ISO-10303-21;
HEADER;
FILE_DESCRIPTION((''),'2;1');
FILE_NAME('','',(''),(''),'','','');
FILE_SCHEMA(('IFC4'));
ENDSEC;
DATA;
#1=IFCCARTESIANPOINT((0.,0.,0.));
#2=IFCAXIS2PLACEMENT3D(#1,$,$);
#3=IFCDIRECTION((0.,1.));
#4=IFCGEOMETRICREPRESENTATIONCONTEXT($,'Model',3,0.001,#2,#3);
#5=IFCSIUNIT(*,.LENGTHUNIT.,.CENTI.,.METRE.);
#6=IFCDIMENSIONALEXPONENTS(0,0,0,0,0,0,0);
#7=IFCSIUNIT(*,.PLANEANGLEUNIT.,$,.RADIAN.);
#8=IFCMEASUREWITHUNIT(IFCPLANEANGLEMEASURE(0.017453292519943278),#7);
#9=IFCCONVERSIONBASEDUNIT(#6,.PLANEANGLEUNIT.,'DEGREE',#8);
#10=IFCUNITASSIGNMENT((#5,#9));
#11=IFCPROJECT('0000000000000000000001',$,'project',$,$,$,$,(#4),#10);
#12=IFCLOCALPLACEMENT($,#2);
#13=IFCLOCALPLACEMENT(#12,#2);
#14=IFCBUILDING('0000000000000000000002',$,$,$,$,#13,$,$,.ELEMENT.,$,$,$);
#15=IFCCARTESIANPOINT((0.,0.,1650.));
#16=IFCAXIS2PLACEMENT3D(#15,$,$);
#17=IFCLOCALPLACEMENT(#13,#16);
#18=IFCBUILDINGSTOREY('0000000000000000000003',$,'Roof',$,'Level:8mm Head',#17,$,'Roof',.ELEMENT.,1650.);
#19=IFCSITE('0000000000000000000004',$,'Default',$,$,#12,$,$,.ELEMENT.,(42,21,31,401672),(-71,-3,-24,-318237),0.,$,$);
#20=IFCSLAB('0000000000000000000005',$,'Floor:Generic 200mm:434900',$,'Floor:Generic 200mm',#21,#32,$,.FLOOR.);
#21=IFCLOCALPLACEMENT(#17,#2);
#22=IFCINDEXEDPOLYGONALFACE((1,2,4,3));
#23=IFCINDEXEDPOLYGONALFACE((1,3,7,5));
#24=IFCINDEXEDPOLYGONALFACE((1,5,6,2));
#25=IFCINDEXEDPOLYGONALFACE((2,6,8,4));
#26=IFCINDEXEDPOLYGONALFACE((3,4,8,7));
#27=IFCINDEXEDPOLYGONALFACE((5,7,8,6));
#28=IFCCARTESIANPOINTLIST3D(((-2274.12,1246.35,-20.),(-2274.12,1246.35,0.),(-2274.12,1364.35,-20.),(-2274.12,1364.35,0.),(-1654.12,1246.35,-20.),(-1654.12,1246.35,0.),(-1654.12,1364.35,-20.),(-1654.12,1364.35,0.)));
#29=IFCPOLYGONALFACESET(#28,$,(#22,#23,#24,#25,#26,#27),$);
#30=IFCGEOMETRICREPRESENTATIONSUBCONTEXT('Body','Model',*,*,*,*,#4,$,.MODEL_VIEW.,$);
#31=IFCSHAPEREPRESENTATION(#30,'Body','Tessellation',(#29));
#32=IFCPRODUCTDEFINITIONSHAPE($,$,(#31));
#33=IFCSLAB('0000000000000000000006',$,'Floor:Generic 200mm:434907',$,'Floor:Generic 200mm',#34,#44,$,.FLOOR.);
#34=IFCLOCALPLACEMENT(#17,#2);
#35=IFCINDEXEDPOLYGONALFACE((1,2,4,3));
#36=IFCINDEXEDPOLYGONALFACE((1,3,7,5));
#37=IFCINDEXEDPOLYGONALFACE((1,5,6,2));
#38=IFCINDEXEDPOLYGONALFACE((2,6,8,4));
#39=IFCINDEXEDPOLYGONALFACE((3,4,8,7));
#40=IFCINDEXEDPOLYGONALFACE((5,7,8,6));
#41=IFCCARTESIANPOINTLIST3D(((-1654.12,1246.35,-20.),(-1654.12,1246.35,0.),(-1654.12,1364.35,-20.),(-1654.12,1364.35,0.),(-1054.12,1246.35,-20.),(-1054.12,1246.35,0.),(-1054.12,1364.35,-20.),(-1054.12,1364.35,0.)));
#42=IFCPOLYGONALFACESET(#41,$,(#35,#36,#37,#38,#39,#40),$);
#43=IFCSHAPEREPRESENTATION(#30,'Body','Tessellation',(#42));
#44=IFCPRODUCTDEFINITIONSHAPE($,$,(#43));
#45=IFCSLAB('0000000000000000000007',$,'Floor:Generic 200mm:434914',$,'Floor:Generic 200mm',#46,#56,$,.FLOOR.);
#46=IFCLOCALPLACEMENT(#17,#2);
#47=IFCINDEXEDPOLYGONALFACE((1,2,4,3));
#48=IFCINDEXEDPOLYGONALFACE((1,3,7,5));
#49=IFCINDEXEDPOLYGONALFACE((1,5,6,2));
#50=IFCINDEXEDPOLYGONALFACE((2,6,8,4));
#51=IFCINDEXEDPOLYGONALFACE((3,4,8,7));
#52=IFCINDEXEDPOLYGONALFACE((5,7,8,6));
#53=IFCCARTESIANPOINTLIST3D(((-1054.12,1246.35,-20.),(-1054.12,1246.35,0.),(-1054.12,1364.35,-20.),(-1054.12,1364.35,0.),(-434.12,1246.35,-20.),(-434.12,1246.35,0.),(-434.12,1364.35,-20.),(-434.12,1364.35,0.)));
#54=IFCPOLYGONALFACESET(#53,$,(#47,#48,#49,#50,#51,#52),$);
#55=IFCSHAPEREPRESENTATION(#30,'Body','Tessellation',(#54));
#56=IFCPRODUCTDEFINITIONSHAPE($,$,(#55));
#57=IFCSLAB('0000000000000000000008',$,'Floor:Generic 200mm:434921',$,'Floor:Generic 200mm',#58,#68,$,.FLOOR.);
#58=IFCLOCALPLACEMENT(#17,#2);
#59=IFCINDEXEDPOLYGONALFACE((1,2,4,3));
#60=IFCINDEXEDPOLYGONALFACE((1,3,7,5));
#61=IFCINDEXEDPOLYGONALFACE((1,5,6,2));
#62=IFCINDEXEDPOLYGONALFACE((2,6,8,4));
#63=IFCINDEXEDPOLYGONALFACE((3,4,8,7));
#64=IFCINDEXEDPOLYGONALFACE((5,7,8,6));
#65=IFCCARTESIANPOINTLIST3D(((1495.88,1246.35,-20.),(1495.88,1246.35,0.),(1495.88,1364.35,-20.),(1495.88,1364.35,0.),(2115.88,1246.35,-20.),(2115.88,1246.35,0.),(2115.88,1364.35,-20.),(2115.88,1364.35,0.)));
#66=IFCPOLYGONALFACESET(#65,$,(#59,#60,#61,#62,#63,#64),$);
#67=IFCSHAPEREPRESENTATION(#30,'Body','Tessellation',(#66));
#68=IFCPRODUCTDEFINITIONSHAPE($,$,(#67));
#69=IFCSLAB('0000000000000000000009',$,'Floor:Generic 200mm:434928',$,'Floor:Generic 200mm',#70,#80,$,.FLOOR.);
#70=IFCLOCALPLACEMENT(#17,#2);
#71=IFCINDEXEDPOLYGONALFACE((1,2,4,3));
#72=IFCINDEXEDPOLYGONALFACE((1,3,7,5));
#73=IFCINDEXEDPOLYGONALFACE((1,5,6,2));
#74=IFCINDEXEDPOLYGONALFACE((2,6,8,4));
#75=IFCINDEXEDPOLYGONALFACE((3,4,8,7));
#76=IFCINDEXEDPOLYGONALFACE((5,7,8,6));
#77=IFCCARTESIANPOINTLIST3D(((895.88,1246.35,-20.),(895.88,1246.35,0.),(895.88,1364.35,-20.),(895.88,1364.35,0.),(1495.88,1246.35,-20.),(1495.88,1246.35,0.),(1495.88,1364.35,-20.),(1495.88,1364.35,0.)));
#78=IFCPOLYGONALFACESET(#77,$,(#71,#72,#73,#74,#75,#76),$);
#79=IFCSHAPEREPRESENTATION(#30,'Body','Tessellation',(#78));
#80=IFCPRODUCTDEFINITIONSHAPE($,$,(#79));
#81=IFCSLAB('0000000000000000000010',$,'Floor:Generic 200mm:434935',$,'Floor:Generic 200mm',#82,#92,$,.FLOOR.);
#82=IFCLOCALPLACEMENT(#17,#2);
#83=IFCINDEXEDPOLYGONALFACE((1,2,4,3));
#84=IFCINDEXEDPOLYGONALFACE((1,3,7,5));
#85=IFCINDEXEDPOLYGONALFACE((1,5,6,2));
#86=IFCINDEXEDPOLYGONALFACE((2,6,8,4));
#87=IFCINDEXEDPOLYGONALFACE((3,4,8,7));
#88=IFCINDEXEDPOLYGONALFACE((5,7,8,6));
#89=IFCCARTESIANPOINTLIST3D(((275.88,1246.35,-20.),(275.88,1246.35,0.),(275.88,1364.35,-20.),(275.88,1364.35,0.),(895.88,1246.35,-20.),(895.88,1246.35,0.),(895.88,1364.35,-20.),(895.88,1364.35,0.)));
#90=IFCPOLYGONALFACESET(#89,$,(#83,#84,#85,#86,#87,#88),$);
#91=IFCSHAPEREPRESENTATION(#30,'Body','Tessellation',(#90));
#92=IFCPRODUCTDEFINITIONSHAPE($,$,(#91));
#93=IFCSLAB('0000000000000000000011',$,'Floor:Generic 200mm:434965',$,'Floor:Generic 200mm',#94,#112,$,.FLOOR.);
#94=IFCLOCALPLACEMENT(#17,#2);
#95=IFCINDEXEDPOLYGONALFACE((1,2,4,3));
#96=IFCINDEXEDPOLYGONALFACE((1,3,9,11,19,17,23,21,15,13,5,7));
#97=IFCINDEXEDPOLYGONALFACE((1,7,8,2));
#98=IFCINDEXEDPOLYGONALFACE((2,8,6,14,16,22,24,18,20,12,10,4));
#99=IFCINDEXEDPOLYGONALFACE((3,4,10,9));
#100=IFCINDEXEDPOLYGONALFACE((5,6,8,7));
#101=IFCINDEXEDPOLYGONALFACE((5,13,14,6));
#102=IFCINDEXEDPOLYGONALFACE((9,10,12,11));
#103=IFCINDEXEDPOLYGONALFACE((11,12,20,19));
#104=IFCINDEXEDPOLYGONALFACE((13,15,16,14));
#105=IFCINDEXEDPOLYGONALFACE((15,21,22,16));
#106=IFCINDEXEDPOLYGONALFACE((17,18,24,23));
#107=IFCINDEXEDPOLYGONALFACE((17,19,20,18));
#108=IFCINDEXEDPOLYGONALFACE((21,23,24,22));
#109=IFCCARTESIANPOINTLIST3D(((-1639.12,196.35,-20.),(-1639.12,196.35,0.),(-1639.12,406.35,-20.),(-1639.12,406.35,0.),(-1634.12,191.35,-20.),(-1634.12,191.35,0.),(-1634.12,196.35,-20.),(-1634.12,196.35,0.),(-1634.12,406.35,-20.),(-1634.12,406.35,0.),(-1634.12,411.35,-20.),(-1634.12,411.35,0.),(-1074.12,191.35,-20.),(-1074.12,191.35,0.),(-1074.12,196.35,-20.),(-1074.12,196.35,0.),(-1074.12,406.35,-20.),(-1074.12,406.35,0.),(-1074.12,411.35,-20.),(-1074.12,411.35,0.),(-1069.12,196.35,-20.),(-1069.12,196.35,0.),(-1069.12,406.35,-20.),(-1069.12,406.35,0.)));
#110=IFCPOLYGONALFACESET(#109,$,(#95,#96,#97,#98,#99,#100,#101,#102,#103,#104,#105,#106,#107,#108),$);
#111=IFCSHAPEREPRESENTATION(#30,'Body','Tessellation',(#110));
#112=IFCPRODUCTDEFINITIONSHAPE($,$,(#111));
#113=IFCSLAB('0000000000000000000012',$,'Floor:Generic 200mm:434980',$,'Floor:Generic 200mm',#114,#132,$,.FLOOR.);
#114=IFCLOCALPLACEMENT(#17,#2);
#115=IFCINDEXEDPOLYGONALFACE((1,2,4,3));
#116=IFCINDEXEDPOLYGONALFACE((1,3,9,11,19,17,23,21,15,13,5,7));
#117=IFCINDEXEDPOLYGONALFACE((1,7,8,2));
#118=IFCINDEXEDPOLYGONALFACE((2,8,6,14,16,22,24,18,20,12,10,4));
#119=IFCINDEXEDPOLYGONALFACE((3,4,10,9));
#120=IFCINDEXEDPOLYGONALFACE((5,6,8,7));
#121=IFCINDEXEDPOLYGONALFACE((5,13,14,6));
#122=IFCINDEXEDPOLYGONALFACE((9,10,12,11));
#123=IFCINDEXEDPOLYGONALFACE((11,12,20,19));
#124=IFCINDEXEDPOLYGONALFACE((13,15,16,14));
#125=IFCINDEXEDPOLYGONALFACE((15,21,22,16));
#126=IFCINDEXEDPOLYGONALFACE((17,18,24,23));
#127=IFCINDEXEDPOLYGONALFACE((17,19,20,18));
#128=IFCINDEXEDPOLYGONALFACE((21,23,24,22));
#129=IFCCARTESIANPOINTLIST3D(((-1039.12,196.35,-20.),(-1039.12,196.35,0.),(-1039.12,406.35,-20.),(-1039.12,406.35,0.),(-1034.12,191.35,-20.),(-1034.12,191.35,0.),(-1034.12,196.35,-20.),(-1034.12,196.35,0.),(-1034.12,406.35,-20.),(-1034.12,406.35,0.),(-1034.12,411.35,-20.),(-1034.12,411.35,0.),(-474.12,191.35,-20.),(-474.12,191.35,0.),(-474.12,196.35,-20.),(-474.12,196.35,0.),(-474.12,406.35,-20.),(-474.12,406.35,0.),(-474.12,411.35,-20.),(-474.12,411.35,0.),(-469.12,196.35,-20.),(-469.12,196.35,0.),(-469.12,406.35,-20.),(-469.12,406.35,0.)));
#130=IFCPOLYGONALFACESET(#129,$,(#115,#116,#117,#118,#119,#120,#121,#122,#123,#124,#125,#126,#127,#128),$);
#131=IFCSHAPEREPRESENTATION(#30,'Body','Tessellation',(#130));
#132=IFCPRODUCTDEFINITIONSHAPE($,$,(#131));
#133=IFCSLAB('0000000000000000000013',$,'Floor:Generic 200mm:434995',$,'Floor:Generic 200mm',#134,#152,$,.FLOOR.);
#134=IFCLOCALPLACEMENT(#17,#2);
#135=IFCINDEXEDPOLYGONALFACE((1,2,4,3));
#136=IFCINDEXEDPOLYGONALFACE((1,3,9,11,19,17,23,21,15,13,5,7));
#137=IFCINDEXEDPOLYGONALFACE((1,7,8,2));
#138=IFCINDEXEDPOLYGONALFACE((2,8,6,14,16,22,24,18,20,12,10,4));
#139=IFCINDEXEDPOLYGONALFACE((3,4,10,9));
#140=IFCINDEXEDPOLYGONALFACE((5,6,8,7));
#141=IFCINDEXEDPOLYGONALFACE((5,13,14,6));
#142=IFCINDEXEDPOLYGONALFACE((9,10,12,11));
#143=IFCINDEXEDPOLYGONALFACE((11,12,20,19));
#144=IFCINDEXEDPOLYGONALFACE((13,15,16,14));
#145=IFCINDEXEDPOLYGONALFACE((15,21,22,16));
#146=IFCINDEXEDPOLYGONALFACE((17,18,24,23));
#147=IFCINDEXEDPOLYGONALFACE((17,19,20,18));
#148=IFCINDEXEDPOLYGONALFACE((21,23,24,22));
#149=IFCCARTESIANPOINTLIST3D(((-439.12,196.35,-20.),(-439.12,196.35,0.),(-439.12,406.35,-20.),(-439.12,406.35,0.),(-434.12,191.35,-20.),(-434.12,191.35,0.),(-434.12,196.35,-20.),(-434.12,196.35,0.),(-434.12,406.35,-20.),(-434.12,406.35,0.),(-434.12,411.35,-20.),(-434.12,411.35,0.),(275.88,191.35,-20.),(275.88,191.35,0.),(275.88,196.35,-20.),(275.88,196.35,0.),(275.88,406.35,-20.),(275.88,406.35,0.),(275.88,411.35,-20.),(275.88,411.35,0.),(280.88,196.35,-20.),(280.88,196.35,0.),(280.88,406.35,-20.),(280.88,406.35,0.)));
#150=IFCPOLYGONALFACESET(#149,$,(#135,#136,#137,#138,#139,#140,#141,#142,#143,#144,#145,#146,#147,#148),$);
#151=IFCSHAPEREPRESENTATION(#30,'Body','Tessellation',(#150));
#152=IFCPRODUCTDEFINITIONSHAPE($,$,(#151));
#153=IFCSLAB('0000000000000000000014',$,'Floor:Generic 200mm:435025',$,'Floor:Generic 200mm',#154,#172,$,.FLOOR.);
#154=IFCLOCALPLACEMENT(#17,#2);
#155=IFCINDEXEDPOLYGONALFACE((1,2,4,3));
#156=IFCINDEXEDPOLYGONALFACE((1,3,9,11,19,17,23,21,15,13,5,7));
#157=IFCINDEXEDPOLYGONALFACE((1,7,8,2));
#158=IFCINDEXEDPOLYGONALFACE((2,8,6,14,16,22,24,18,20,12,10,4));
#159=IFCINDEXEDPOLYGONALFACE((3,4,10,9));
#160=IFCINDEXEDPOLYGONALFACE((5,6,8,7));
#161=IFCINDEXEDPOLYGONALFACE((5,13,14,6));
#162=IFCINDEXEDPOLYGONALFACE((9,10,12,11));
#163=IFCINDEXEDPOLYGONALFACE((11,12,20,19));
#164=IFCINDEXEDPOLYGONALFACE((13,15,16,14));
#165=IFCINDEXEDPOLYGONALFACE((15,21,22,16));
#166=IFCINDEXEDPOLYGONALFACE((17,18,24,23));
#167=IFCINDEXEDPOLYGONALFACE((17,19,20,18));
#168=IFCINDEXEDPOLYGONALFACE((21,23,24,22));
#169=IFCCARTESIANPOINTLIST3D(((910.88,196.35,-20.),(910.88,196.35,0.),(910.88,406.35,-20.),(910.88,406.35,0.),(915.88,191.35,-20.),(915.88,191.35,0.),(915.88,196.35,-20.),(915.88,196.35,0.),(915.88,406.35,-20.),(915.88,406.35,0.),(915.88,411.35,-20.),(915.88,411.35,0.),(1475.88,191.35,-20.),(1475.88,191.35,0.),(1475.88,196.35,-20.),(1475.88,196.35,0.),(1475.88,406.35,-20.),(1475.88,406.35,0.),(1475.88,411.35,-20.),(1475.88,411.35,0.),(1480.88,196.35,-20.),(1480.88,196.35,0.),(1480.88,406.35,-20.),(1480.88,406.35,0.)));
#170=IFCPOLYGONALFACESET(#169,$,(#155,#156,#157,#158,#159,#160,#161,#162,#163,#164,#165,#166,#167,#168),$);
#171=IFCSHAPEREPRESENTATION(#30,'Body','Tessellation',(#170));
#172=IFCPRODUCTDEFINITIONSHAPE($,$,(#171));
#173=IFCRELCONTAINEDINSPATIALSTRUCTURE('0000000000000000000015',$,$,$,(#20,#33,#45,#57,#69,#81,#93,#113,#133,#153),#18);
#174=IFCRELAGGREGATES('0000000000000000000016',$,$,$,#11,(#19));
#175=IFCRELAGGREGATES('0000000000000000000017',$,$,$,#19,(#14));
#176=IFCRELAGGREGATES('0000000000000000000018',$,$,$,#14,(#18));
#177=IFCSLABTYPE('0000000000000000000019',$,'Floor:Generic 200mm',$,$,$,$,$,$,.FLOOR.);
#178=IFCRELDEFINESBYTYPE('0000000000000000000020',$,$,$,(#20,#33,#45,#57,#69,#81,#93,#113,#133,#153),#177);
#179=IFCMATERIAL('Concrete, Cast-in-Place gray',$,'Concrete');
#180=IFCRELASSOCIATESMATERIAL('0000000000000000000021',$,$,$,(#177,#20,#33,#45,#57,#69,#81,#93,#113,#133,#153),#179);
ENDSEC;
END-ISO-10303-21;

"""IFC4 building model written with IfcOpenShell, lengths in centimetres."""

from ifc_helpers import new_model, entity, si_unit, converted_unit, direction, frame, origin, place, context, subcontext, project, spatial, indexed_curve, outline, extrude, material, type_object, element, save


model = new_model("IFC4")

# Units and contexts
model_context = context("Model", 3, precision=0.001, world=origin(), true_north=direction((0.0, 1.0)))
body_context = subcontext(model_context, "Body", "Model", "MODEL_VIEW")
ifc_project = project(units=[si_unit("LENGTHUNIT", "METRE", prefix="CENTI"), converted_unit("PLANEANGLEUNIT", "DEGREE", entity("IfcPlaneAngleMeasure", 0.017453292519943278), si_unit("PLANEANGLEUNIT", "RADIAN"), dimensions=[0, 0, 0, 0, 0, 0, 0])], contexts=[model_context])

# Site, building, storey
site_placement = place(None, origin())
site = spatial("IfcSite", under=ifc_project, at=site_placement, Name="Default", CompositionType="ELEMENT", RefLatitude=(42, 21, 31, 401672), RefLongitude=(-71, -3, -24, -318237), RefElevation=0.0)
building_placement = place(site_placement, origin())
building = spatial("IfcBuilding", under=site, at=building_placement, CompositionType="ELEMENT")
storey_placement = place(building_placement, frame((0.0, 0.0, 1650.0)))
storey = spatial("IfcBuildingStorey", under=building, at=storey_placement, Name="Roof", ObjectType="Level:8mm Head", LongName="Roof", CompositionType="ELEMENT", Elevation=1650.0)

# Slabs
ifc_material = material(Name="Concrete, Cast-in-Place gray", Category="Concrete")
slab_type = type_object("IfcSlabType", Name="Floor:Generic 200mm", PredefinedType="FLOOR", material=ifc_material)
slab_1_placement = place(storey_placement, origin())
element("IfcSlab", 1, at=slab_1_placement, inside=storey, type_object=slab_type, material=ifc_material, Name="Floor:Generic 200mm:434900", ObjectType="Floor:Generic 200mm", PredefinedType="FLOOR", context=body_context, shape_type="SweptSolid", body=[
    extrude(outline(indexed_curve([(-59.0, -310.0), (59.0, -310.0), (59.0, 310.0), (-59.0, 310.0), (-59.0, -310.0)], self_intersect=False)), frame((-1964.12, 1305.35, 0.0), z_axis=(0.0, 0.0, -1.0), x_axis=(0.0, 1.0, 0.0)), (0.0, 0.0, 1.0), 20.0),
])
slab_2_placement = place(storey_placement, origin())
element("IfcSlab", 2, at=slab_2_placement, inside=storey, type_object=slab_type, material=ifc_material, Name="Floor:Generic 200mm:434907", ObjectType="Floor:Generic 200mm", PredefinedType="FLOOR", context=body_context, shape_type="SweptSolid", body=[
    extrude(outline(indexed_curve([(-59.0, -300.0), (59.0, -300.0), (59.0, 300.0), (-59.0, 300.0), (-59.0, -300.0)], self_intersect=False)), frame((-1354.12, 1305.35, 0.0), z_axis=(0.0, 0.0, -1.0), x_axis=(0.0, 1.0, 0.0)), (0.0, 0.0, 1.0), 20.0),
])
slab_3_placement = place(storey_placement, origin())
element("IfcSlab", 3, at=slab_3_placement, inside=storey, type_object=slab_type, material=ifc_material, Name="Floor:Generic 200mm:434914", ObjectType="Floor:Generic 200mm", PredefinedType="FLOOR", context=body_context, shape_type="SweptSolid", body=[
    extrude(outline(indexed_curve([(-59.0, -310.0), (59.0, -310.0), (59.0, 310.0), (-59.0, 310.0), (-59.0, -310.0)], self_intersect=False)), frame((-744.12, 1305.35, 0.0), z_axis=(0.0, 0.0, -1.0), x_axis=(0.0, 1.0, 0.0)), (0.0, 0.0, 1.0), 20.0),
])
slab_4_placement = place(storey_placement, origin())
element("IfcSlab", 4, at=slab_4_placement, inside=storey, type_object=slab_type, material=ifc_material, Name="Floor:Generic 200mm:434921", ObjectType="Floor:Generic 200mm", PredefinedType="FLOOR", context=body_context, shape_type="SweptSolid", body=[
    extrude(outline(indexed_curve([(-59.0, -310.0), (59.0, -310.0), (59.0, 310.0), (-59.0, 310.0), (-59.0, -310.0)], self_intersect=False)), frame((1805.88, 1305.35, 0.0), z_axis=(0.0, 0.0, -1.0), x_axis=(0.0, 1.0, 0.0)), (0.0, 0.0, 1.0), 20.0),
])
slab_5_placement = place(storey_placement, origin())
element("IfcSlab", 5, at=slab_5_placement, inside=storey, type_object=slab_type, material=ifc_material, Name="Floor:Generic 200mm:434928", ObjectType="Floor:Generic 200mm", PredefinedType="FLOOR", context=body_context, shape_type="SweptSolid", body=[
    extrude(outline(indexed_curve([(-59.0, -300.0), (59.0, -300.0), (59.0, 300.0), (-59.0, 300.0), (-59.0, -300.0)], self_intersect=False)), frame((1195.88, 1305.35, 0.0), z_axis=(0.0, 0.0, -1.0), x_axis=(0.0, 1.0, 0.0)), (0.0, 0.0, 1.0), 20.0),
])
slab_6_placement = place(storey_placement, origin())
element("IfcSlab", 6, at=slab_6_placement, inside=storey, type_object=slab_type, material=ifc_material, Name="Floor:Generic 200mm:434935", ObjectType="Floor:Generic 200mm", PredefinedType="FLOOR", context=body_context, shape_type="SweptSolid", body=[
    extrude(outline(indexed_curve([(-59.0, -310.0), (59.0, -310.0), (59.0, 310.0), (-59.0, 310.0), (-59.0, -310.0)], self_intersect=False)), frame((585.88, 1305.35, 0.0), z_axis=(0.0, 0.0, -1.0), x_axis=(0.0, 1.0, 0.0)), (0.0, 0.0, 1.0), 20.0),
])
slab_7_placement = place(storey_placement, origin())
element("IfcSlab", 7, at=slab_7_placement, inside=storey, type_object=slab_type, material=ifc_material, Name="Floor:Generic 200mm:434965", ObjectType="Floor:Generic 200mm", PredefinedType="FLOOR", context=body_context, shape_type="SweptSolid", body=[
    extrude(outline(indexed_curve([(-105.0, -285.0), (105.0, -285.0), (105.0, -280.0), (110.0, -280.0), (110.0, 280.0), (105.0, 280.0), (105.0, 285.0), (-105.0, 285.0), (-105.0, 280.0), (-110.0, 280.0), (-110.0, -280.0), (-105.0, -280.0), (-105.0, -285.0)], self_intersect=False)), frame((-1354.12, 301.35, 0.0), z_axis=(0.0, 0.0, -1.0), x_axis=(0.0, 1.0, 0.0)), (0.0, 0.0, 1.0), 20.0),
])
slab_8_placement = place(storey_placement, origin())
element("IfcSlab", 8, at=slab_8_placement, inside=storey, type_object=slab_type, material=ifc_material, Name="Floor:Generic 200mm:434980", ObjectType="Floor:Generic 200mm", PredefinedType="FLOOR", context=body_context, shape_type="SweptSolid", body=[
    extrude(outline(indexed_curve([(-105.0, -285.0), (105.0, -285.0), (105.0, -280.0), (110.0, -280.0), (110.0, 280.0), (105.0, 280.0), (105.0, 285.0), (-105.0, 285.0), (-105.0, 280.0), (-110.0, 280.0), (-110.0, -280.0), (-105.0, -280.0), (-105.0, -285.0)], self_intersect=False)), frame((-754.12, 301.35, 0.0), z_axis=(0.0, 0.0, -1.0), x_axis=(0.0, 1.0, 0.0)), (0.0, 0.0, 1.0), 20.0),
])
slab_9_placement = place(storey_placement, origin())
element("IfcSlab", 9, at=slab_9_placement, inside=storey, type_object=slab_type, material=ifc_material, Name="Floor:Generic 200mm:434995", ObjectType="Floor:Generic 200mm", PredefinedType="FLOOR", context=body_context, shape_type="SweptSolid", body=[
    extrude(outline(indexed_curve([(-105.0, -360.0), (105.0, -360.0), (105.0, -355.0), (110.0, -355.0), (110.0, 355.0), (105.0, 355.0), (105.0, 360.0), (-105.0, 360.0), (-105.0, 355.0), (-110.0, 355.0), (-110.0, -355.0), (-105.0, -355.0), (-105.0, -360.0)], self_intersect=False)), frame((-79.12, 301.35, 0.0), z_axis=(0.0, 0.0, -1.0), x_axis=(0.0, 1.0, 0.0)), (0.0, 0.0, 1.0), 20.0),
])
slab_10_placement = place(storey_placement, origin())
element("IfcSlab", 10, at=slab_10_placement, inside=storey, type_object=slab_type, material=ifc_material, Name="Floor:Generic 200mm:435025", ObjectType="Floor:Generic 200mm", PredefinedType="FLOOR", context=body_context, shape_type="SweptSolid", body=[
    extrude(outline(indexed_curve([(-105.0, -285.0), (105.0, -285.0), (105.0, -280.0), (110.0, -280.0), (110.0, 280.0), (105.0, 280.0), (105.0, 285.0), (-105.0, 285.0), (-105.0, 280.0), (-110.0, 280.0), (-110.0, -280.0), (-105.0, -280.0), (-105.0, -285.0)], self_intersect=False)), frame((1195.88, 301.35, 0.0), z_axis=(0.0, 0.0, -1.0), x_axis=(0.0, 1.0, 0.0)), (0.0, 0.0, 1.0), 20.0),
])

save(model, "model.ifc")
